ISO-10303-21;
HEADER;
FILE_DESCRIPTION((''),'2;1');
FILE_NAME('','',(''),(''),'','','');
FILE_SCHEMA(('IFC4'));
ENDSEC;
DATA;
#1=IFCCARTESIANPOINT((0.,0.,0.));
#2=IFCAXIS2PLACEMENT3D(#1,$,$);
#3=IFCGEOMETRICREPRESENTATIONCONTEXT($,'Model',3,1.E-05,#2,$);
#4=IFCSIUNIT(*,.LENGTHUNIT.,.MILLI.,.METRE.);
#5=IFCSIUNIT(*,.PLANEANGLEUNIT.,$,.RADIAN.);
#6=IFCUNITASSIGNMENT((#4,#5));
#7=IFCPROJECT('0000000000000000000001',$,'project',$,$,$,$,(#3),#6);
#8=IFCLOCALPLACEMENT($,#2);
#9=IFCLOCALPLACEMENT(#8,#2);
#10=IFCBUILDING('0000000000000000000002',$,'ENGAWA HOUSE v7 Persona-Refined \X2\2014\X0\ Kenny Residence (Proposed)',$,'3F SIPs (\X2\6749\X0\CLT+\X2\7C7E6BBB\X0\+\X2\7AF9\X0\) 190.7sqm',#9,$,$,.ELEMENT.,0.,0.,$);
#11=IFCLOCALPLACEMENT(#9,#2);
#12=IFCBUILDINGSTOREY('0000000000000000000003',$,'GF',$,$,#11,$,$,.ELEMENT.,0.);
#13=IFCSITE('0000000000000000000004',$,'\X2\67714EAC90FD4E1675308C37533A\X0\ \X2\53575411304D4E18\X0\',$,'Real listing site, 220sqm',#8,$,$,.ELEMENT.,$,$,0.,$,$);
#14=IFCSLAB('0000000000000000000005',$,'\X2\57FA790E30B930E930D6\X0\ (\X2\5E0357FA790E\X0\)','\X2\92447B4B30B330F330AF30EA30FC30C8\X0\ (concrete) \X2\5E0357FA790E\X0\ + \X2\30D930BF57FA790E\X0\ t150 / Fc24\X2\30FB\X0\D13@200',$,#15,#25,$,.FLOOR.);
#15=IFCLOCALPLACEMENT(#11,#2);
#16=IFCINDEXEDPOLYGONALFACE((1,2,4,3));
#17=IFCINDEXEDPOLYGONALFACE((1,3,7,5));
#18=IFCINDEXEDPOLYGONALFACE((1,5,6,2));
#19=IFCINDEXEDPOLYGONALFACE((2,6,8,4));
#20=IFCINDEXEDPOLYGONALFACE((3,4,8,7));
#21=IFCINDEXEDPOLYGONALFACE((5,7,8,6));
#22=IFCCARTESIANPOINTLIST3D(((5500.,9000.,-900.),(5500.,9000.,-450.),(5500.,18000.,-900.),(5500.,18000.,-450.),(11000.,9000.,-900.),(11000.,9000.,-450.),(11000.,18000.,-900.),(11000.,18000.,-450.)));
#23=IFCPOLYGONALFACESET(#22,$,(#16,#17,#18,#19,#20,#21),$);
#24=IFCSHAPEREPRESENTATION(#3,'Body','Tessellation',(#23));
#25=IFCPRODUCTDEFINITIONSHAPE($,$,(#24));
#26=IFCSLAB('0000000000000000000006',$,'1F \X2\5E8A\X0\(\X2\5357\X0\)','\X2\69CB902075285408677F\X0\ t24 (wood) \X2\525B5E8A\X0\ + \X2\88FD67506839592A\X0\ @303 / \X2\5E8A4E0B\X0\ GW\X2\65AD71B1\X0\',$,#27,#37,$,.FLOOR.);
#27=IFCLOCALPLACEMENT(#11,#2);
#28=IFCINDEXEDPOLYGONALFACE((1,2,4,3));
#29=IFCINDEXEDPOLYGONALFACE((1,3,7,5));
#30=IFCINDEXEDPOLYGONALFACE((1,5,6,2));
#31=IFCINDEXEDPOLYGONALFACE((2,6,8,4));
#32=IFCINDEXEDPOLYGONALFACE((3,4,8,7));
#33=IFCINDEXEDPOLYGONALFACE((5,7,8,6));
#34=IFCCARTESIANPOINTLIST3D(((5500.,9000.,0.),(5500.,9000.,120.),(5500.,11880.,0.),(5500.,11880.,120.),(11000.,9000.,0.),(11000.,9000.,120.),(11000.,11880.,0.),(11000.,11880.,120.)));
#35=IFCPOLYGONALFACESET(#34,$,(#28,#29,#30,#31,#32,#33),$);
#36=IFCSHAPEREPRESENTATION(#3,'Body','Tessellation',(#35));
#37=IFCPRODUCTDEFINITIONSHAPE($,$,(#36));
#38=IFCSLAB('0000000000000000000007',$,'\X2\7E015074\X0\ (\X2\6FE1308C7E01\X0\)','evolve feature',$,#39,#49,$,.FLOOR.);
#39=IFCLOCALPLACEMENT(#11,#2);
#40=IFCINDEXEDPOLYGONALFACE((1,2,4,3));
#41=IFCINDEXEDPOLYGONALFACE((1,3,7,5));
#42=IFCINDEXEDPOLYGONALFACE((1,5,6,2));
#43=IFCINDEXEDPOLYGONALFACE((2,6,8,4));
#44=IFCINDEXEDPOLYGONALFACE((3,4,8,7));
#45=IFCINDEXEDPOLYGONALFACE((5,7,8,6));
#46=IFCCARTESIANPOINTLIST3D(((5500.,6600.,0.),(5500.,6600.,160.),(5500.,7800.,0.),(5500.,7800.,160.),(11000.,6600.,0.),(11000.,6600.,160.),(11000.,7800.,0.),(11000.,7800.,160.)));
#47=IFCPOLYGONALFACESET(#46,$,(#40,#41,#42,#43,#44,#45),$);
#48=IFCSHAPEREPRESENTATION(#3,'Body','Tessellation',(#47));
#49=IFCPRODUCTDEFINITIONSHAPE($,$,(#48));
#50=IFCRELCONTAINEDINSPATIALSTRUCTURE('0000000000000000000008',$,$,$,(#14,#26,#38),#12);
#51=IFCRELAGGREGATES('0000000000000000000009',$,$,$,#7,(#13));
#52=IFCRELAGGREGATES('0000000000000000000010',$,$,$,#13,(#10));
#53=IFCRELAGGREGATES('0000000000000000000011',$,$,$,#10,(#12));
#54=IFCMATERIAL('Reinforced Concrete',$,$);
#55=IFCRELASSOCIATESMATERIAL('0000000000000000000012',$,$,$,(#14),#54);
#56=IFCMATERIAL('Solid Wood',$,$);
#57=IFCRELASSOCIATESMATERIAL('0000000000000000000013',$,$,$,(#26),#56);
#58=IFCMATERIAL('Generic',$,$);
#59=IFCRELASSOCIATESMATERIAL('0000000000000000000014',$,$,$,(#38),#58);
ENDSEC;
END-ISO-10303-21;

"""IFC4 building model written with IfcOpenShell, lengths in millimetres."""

from ifc_helpers import new_model, si_unit, frame, frame_2d, origin, place, context, project, spatial, rectangle, extrude, material, element, save


model = new_model("IFC4")

# Units and contexts
model_context = context("Model", 3, precision=1e-05, world=origin())
ifc_project = project(units=[si_unit("LENGTHUNIT", "METRE", prefix="MILLI"), si_unit("PLANEANGLEUNIT", "RADIAN")], contexts=[model_context])

# Site, building, storey
site_placement = place(None, origin())
site = spatial("IfcSite", under=ifc_project, at=site_placement, Name="東京都世田谷区 南向き丘", ObjectType="Real listing site, 220sqm", CompositionType="ELEMENT", RefElevation=0.0)
building_placement = place(site_placement, origin())
building = spatial("IfcBuilding", under=site, at=building_placement, Name="ENGAWA HOUSE v7 Persona-Refined — Kenny Residence (Proposed)", ObjectType="3F SIPs (杉CLT+籾殻+竹) 190.7sqm", CompositionType="ELEMENT", ElevationOfRefHeight=0.0, ElevationOfTerrain=0.0)
storey_placement = place(building_placement, origin())
storey = spatial("IfcBuildingStorey", under=building, at=storey_placement, Name="GF", CompositionType="ELEMENT", Elevation=0.0)

# Slabs
ifc_material_1 = material(Name="Reinforced Concrete")
slab_1_placement = place(storey_placement, frame((2750.0, 4500.0, -450.0)))
element("IfcSlab", 1, at=slab_1_placement, inside=storey, material=ifc_material_1, Name="基礎スラブ (布基礎)", Description="鉄筋コンクリート (concrete) 布基礎 + ベタ基礎 t150 / Fc24・D13@200", PredefinedType="FLOOR", context=model_context, shape_type="SweptSolid", body=[
    extrude(rectangle(XDim=5500.0, YDim=9000.0, at=frame_2d((2750.0, 4500.0))), frame((2750.0, 4500.0, -450.0)), (0.0, 0.0, 1.0), 450.0),
])
ifc_material_2 = material(Name="Solid Wood")
slab_2_placement = place(storey_placement, frame((2750.0, 4500.0, 0.0)))
element("IfcSlab", 2, at=slab_2_placement, inside=storey, material=ifc_material_2, Name="1F 床(南)", Description="構造用合板 t24 (wood) 剛床 + 製材根太 @303 / 床下 GW断熱", PredefinedType="FLOOR", context=model_context, shape_type="SweptSolid", body=[
    extrude(rectangle(XDim=5500.0, YDim=2880.0, at=frame_2d((2750.0, 1440.0))), frame((2750.0, 4500.0, 0.0)), (0.0, 0.0, 1.0), 120.0),
])
ifc_material_3 = material(Name="Generic")
slab_3_placement = place(storey_placement, frame((2750.0, 3300.0, 0.0)))
element("IfcSlab", 3, at=slab_3_placement, inside=storey, material=ifc_material_3, Name="縁側 (濡れ縁)", Description="evolve feature", PredefinedType="FLOOR", context=model_context, shape_type="SweptSolid", body=[
    extrude(rectangle(XDim=5500.0, YDim=1200.0, at=frame_2d((2750.0, 600.0))), frame((2750.0, 3300.0, 0.0)), (0.0, 0.0, 1.0), 160.0),
])

save(model, "model.ifc")
